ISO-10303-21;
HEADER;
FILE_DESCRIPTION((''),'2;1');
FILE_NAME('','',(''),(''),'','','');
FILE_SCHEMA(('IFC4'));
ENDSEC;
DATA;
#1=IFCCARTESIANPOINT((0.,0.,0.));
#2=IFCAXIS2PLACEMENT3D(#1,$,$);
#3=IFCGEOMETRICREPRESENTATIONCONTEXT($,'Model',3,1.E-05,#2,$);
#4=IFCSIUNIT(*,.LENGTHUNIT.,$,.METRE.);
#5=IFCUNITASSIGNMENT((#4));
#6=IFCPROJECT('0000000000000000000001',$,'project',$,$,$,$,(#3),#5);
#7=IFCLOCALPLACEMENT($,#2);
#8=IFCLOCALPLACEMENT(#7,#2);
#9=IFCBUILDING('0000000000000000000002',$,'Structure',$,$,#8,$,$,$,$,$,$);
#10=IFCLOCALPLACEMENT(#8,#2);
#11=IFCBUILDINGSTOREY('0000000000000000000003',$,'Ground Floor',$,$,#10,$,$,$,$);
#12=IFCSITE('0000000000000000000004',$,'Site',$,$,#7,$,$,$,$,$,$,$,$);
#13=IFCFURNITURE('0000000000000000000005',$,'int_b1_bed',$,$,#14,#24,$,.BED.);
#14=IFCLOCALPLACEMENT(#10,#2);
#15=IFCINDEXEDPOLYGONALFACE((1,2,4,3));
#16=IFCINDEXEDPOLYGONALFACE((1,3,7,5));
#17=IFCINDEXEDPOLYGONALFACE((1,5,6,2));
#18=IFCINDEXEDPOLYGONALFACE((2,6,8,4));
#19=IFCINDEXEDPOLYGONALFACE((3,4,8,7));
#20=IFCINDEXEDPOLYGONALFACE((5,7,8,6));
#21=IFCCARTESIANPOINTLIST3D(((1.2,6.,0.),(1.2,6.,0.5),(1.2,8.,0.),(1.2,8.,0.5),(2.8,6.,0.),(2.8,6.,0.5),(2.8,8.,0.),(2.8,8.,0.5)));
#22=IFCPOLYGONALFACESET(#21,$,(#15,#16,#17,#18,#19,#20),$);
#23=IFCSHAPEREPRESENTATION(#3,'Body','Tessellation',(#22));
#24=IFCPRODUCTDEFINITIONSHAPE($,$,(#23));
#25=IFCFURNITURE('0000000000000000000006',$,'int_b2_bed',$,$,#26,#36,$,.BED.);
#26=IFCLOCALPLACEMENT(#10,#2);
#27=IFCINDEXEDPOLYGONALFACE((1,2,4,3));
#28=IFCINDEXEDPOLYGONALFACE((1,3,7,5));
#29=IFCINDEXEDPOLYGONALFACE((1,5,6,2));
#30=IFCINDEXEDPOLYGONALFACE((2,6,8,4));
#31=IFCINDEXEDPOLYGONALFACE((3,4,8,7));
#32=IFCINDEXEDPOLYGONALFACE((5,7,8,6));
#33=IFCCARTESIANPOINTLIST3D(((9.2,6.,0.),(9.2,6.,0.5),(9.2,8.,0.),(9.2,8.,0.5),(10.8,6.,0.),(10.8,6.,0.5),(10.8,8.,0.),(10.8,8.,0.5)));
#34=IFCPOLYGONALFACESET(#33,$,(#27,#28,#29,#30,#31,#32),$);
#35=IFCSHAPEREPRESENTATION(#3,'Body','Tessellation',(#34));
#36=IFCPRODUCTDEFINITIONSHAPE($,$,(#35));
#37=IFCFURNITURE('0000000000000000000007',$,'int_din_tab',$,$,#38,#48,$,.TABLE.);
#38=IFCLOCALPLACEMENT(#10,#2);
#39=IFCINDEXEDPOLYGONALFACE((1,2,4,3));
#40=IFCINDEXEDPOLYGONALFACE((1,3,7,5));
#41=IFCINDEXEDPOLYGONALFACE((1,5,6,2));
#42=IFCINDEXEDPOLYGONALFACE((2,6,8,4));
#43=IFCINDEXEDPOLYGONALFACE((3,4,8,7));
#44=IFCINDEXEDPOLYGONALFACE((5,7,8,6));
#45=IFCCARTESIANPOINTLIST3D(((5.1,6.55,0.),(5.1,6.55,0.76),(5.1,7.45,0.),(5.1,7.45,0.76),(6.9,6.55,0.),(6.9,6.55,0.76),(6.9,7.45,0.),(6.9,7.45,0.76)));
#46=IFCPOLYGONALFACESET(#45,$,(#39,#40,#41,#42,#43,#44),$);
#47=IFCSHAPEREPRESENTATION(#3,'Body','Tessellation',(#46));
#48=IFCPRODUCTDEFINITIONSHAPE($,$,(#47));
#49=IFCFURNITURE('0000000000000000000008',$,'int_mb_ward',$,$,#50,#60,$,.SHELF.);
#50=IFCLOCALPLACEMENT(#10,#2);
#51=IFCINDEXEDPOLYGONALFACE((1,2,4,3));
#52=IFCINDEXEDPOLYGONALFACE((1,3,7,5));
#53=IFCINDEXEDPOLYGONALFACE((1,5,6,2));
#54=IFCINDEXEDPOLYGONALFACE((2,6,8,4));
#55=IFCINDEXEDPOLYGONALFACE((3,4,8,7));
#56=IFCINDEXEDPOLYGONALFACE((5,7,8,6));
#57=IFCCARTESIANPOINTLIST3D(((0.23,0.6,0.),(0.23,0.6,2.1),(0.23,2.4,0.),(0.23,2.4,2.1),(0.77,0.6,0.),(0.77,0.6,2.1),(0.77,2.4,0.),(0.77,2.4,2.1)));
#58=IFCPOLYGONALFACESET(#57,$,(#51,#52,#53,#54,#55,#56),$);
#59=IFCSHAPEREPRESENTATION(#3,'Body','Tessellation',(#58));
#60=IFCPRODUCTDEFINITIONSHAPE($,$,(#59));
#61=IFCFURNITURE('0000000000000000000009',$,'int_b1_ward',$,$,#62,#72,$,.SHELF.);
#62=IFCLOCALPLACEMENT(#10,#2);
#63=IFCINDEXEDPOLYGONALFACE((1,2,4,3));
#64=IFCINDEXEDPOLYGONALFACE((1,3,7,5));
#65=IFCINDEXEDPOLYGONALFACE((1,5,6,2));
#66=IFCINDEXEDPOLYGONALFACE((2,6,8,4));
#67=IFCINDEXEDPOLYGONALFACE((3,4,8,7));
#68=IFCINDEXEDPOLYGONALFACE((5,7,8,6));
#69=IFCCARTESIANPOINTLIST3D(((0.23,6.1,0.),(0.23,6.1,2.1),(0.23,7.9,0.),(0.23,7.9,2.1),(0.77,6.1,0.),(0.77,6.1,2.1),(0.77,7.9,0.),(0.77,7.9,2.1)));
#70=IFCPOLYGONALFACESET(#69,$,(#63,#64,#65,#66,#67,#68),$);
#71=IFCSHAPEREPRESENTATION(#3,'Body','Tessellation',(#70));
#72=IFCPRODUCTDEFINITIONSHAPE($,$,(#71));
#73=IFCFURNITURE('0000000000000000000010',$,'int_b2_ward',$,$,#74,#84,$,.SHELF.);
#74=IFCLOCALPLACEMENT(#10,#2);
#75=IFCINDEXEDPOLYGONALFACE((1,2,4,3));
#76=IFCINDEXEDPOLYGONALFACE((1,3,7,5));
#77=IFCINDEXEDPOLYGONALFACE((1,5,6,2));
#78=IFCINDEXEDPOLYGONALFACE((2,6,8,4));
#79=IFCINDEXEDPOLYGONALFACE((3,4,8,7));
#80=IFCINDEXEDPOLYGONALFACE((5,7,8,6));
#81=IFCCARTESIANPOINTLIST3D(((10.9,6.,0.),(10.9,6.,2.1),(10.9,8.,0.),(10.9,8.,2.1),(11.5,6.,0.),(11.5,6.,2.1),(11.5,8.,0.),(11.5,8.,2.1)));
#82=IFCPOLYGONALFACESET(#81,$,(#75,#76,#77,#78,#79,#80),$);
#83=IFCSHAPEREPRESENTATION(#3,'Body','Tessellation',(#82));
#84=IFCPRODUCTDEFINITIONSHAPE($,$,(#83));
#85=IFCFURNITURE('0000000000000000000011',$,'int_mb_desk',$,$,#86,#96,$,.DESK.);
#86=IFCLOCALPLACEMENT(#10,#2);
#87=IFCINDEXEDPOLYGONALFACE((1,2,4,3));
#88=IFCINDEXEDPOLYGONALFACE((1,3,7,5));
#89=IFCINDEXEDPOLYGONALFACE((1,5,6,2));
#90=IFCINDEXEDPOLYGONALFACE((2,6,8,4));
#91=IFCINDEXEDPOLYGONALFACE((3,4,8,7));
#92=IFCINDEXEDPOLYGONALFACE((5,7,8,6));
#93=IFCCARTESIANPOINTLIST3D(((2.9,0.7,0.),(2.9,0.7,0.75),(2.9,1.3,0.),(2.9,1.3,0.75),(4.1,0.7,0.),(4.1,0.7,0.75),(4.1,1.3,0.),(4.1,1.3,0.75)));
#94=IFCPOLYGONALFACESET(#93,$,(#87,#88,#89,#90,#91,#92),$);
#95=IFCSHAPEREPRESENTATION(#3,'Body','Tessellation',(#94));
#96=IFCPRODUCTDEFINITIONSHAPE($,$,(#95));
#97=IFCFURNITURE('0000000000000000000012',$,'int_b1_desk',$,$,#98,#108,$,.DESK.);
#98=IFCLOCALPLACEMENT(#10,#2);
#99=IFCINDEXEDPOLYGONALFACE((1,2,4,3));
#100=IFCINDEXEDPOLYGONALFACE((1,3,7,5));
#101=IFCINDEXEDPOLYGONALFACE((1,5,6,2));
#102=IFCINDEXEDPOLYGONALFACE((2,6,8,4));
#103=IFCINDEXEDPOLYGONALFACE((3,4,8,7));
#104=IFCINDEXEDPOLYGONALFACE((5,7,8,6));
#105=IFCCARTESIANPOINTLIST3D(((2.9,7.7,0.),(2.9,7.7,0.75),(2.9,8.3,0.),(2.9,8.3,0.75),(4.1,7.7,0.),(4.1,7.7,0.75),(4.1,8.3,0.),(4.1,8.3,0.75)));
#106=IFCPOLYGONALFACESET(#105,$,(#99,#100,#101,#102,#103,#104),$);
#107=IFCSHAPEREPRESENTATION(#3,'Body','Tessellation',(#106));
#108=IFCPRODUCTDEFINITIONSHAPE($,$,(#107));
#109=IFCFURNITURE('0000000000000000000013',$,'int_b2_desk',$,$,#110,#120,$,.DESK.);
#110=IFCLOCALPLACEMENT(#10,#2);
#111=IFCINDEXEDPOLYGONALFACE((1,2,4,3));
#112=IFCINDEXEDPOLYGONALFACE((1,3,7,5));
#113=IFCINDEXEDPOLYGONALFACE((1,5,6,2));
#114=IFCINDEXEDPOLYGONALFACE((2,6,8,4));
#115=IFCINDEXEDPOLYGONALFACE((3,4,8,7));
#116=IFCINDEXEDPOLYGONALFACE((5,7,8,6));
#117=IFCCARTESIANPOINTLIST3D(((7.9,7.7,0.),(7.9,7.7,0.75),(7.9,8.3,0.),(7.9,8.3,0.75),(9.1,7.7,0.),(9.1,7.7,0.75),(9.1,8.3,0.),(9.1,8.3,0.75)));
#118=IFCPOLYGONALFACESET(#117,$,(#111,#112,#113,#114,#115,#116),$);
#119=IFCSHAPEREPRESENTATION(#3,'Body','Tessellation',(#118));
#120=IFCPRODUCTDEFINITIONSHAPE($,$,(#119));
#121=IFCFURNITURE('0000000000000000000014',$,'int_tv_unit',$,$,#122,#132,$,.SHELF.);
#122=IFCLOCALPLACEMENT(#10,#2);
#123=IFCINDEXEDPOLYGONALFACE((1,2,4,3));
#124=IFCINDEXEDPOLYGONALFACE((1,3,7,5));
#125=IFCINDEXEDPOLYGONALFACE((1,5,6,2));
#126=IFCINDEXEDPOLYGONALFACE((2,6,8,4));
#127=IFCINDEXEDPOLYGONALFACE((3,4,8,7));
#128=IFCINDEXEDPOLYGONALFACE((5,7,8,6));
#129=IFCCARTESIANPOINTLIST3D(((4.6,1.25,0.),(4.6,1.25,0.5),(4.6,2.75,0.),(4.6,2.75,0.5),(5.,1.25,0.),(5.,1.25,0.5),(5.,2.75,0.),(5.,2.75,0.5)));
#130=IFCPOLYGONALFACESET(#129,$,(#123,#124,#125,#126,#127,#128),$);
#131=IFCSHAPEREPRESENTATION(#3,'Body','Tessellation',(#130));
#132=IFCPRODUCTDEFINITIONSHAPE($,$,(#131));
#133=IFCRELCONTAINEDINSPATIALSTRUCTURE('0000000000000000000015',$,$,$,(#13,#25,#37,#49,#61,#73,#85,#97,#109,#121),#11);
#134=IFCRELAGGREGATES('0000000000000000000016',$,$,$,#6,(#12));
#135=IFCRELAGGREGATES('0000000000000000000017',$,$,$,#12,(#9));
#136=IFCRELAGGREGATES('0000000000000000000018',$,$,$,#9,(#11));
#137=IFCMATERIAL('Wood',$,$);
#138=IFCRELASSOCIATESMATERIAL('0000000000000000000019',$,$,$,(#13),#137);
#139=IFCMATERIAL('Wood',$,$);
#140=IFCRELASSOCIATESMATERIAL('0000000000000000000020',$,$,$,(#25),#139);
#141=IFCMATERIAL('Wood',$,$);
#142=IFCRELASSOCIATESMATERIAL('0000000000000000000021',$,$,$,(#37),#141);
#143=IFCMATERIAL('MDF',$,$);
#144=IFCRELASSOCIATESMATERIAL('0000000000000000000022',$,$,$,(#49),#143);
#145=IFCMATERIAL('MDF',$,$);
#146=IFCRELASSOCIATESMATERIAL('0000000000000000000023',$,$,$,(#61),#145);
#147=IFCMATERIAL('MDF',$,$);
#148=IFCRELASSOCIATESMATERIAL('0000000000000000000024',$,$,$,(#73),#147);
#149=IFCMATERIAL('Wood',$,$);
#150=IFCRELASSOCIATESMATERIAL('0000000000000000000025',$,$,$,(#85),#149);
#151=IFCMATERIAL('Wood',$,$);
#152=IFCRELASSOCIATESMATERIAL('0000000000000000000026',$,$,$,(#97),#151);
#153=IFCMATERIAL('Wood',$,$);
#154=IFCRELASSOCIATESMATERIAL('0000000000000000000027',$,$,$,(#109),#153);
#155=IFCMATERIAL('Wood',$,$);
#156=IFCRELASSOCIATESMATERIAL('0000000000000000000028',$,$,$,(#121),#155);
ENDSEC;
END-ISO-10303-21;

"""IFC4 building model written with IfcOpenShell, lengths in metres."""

from ifc_helpers import new_model, si_unit, frame, origin, place, context, project, spatial, polyline, outline, extrude, material, element, save


model = new_model("IFC4")

# Units and contexts
model_context = context("Model", 3, precision=1e-05, world=origin())
ifc_project = project(units=[si_unit("LENGTHUNIT", "METRE")], contexts=[model_context])

# Site, building, storey
site_placement = place(None, origin())
site = spatial("IfcSite", under=ifc_project, at=site_placement, Name="Site")
building_placement = place(site_placement, origin())
building = spatial("IfcBuilding", under=site, at=building_placement, Name="Structure")
storey_placement = place(building_placement, origin())
storey = spatial("IfcBuildingStorey", under=building, at=storey_placement, Name="Ground Floor")

# Furniture
ifc_material_1 = material(Name="Wood")
furniture_1_placement = place(storey_placement, frame((2.0, 7.0, 0.0)))
element("IfcFurniture", 1, at=furniture_1_placement, inside=storey, material=ifc_material_1, Name="int_b1_bed", PredefinedType="BED", context=model_context, shape_type="SweptSolid", body=[
    extrude(outline(polyline([(-0.8, -1.0), (0.8, -1.0), (0.8, 1.0), (-0.8, 1.0), (-0.8, -1.0)])), origin(), (0.0, 0.0, 1.0), 0.5),
])
ifc_material_2 = material(Name="Wood")
furniture_2_placement = place(storey_placement, frame((10.0, 7.0, 0.0)))
element("IfcFurniture", 2, at=furniture_2_placement, inside=storey, material=ifc_material_2, Name="int_b2_bed", PredefinedType="BED", context=model_context, shape_type="SweptSolid", body=[
    extrude(outline(polyline([(-0.8, -1.0), (0.8, -1.0), (0.8, 1.0), (-0.8, 1.0), (-0.8, -1.0)])), origin(), (0.0, 0.0, 1.0), 0.5),
])
ifc_material_3 = material(Name="Wood")
furniture_3_placement = place(storey_placement, frame((6.0, 7.0, 0.0)))
element("IfcFurniture", 3, at=furniture_3_placement, inside=storey, material=ifc_material_3, Name="int_din_tab", PredefinedType="TABLE", context=model_context, shape_type="SweptSolid", body=[
    extrude(outline(polyline([(-0.9, -0.45), (0.9, -0.45), (0.9, 0.45), (-0.9, 0.45), (-0.9, -0.45)])), origin(), (0.0, 0.0, 1.0), 0.76),
])
ifc_material_4 = material(Name="MDF")
furniture_4_placement = place(storey_placement, frame((0.5, 1.5, 0.0)))
element("IfcFurniture", 4, at=furniture_4_placement, inside=storey, material=ifc_material_4, Name="int_mb_ward", PredefinedType="SHELF", context=model_context, shape_type="SweptSolid", body=[
    extrude(outline(polyline([(-0.27, -0.9), (0.27, -0.9), (0.27, 0.9), (-0.27, 0.9), (-0.27, -0.9)])), origin(), (0.0, 0.0, 1.0), 2.1),
])
ifc_material_5 = material(Name="MDF")
furniture_5_placement = place(storey_placement, frame((0.5, 7.0, 0.0)))
element("IfcFurniture", 5, at=furniture_5_placement, inside=storey, material=ifc_material_5, Name="int_b1_ward", PredefinedType="SHELF", context=model_context, shape_type="SweptSolid", body=[
    extrude(outline(polyline([(-0.27, -0.9), (0.27, -0.9), (0.27, 0.9), (-0.27, 0.9), (-0.27, -0.9)])), origin(), (0.0, 0.0, 1.0), 2.1),
])
ifc_material_6 = material(Name="MDF")
furniture_6_placement = place(storey_placement, frame((11.2, 7.0, 0.0)))
element("IfcFurniture", 6, at=furniture_6_placement, inside=storey, material=ifc_material_6, Name="int_b2_ward", PredefinedType="SHELF", context=model_context, shape_type="SweptSolid", body=[
    extrude(outline(polyline([(-0.3, -1.0), (0.3, -1.0), (0.3, 1.0), (-0.3, 1.0), (-0.3, -1.0)])), origin(), (0.0, 0.0, 1.0), 2.1),
])
ifc_material_7 = material(Name="Wood")
furniture_7_placement = place(storey_placement, frame((3.5, 1.0, 0.0)))
element("IfcFurniture", 7, at=furniture_7_placement, inside=storey, material=ifc_material_7, Name="int_mb_desk", PredefinedType="DESK", context=model_context, shape_type="SweptSolid", body=[
    extrude(outline(polyline([(-0.6, -0.3), (0.6, -0.3), (0.6, 0.3), (-0.6, 0.3), (-0.6, -0.3)])), origin(), (0.0, 0.0, 1.0), 0.75),
])
ifc_material_8 = material(Name="Wood")
furniture_8_placement = place(storey_placement, frame((3.5, 8.0, 0.0)))
element("IfcFurniture", 8, at=furniture_8_placement, inside=storey, material=ifc_material_8, Name="int_b1_desk", PredefinedType="DESK", context=model_context, shape_type="SweptSolid", body=[
    extrude(outline(polyline([(-0.6, -0.3), (0.6, -0.3), (0.6, 0.3), (-0.6, 0.3), (-0.6, -0.3)])), origin(), (0.0, 0.0, 1.0), 0.75),
])
ifc_material_9 = material(Name="Wood")
furniture_9_placement = place(storey_placement, frame((8.5, 8.0, 0.0)))
element("IfcFurniture", 9, at=furniture_9_placement, inside=storey, material=ifc_material_9, Name="int_b2_desk", PredefinedType="DESK", context=model_context, shape_type="SweptSolid", body=[
    extrude(outline(polyline([(-0.6, -0.3), (0.6, -0.3), (0.6, 0.3), (-0.6, 0.3), (-0.6, -0.3)])), origin(), (0.0, 0.0, 1.0), 0.75),
])
ifc_material_10 = material(Name="Wood")
furniture_10_placement = place(storey_placement, frame((4.8, 2.0, 0.0)))
element("IfcFurniture", 10, at=furniture_10_placement, inside=storey, material=ifc_material_10, Name="int_tv_unit", PredefinedType="SHELF", context=model_context, shape_type="SweptSolid", body=[
    extrude(outline(polyline([(-0.2, -0.75), (0.2, -0.75), (0.2, 0.75), (-0.2, 0.75), (-0.2, -0.75)])), origin(), (0.0, 0.0, 1.0), 0.5),
])

save(model, "model.ifc")
